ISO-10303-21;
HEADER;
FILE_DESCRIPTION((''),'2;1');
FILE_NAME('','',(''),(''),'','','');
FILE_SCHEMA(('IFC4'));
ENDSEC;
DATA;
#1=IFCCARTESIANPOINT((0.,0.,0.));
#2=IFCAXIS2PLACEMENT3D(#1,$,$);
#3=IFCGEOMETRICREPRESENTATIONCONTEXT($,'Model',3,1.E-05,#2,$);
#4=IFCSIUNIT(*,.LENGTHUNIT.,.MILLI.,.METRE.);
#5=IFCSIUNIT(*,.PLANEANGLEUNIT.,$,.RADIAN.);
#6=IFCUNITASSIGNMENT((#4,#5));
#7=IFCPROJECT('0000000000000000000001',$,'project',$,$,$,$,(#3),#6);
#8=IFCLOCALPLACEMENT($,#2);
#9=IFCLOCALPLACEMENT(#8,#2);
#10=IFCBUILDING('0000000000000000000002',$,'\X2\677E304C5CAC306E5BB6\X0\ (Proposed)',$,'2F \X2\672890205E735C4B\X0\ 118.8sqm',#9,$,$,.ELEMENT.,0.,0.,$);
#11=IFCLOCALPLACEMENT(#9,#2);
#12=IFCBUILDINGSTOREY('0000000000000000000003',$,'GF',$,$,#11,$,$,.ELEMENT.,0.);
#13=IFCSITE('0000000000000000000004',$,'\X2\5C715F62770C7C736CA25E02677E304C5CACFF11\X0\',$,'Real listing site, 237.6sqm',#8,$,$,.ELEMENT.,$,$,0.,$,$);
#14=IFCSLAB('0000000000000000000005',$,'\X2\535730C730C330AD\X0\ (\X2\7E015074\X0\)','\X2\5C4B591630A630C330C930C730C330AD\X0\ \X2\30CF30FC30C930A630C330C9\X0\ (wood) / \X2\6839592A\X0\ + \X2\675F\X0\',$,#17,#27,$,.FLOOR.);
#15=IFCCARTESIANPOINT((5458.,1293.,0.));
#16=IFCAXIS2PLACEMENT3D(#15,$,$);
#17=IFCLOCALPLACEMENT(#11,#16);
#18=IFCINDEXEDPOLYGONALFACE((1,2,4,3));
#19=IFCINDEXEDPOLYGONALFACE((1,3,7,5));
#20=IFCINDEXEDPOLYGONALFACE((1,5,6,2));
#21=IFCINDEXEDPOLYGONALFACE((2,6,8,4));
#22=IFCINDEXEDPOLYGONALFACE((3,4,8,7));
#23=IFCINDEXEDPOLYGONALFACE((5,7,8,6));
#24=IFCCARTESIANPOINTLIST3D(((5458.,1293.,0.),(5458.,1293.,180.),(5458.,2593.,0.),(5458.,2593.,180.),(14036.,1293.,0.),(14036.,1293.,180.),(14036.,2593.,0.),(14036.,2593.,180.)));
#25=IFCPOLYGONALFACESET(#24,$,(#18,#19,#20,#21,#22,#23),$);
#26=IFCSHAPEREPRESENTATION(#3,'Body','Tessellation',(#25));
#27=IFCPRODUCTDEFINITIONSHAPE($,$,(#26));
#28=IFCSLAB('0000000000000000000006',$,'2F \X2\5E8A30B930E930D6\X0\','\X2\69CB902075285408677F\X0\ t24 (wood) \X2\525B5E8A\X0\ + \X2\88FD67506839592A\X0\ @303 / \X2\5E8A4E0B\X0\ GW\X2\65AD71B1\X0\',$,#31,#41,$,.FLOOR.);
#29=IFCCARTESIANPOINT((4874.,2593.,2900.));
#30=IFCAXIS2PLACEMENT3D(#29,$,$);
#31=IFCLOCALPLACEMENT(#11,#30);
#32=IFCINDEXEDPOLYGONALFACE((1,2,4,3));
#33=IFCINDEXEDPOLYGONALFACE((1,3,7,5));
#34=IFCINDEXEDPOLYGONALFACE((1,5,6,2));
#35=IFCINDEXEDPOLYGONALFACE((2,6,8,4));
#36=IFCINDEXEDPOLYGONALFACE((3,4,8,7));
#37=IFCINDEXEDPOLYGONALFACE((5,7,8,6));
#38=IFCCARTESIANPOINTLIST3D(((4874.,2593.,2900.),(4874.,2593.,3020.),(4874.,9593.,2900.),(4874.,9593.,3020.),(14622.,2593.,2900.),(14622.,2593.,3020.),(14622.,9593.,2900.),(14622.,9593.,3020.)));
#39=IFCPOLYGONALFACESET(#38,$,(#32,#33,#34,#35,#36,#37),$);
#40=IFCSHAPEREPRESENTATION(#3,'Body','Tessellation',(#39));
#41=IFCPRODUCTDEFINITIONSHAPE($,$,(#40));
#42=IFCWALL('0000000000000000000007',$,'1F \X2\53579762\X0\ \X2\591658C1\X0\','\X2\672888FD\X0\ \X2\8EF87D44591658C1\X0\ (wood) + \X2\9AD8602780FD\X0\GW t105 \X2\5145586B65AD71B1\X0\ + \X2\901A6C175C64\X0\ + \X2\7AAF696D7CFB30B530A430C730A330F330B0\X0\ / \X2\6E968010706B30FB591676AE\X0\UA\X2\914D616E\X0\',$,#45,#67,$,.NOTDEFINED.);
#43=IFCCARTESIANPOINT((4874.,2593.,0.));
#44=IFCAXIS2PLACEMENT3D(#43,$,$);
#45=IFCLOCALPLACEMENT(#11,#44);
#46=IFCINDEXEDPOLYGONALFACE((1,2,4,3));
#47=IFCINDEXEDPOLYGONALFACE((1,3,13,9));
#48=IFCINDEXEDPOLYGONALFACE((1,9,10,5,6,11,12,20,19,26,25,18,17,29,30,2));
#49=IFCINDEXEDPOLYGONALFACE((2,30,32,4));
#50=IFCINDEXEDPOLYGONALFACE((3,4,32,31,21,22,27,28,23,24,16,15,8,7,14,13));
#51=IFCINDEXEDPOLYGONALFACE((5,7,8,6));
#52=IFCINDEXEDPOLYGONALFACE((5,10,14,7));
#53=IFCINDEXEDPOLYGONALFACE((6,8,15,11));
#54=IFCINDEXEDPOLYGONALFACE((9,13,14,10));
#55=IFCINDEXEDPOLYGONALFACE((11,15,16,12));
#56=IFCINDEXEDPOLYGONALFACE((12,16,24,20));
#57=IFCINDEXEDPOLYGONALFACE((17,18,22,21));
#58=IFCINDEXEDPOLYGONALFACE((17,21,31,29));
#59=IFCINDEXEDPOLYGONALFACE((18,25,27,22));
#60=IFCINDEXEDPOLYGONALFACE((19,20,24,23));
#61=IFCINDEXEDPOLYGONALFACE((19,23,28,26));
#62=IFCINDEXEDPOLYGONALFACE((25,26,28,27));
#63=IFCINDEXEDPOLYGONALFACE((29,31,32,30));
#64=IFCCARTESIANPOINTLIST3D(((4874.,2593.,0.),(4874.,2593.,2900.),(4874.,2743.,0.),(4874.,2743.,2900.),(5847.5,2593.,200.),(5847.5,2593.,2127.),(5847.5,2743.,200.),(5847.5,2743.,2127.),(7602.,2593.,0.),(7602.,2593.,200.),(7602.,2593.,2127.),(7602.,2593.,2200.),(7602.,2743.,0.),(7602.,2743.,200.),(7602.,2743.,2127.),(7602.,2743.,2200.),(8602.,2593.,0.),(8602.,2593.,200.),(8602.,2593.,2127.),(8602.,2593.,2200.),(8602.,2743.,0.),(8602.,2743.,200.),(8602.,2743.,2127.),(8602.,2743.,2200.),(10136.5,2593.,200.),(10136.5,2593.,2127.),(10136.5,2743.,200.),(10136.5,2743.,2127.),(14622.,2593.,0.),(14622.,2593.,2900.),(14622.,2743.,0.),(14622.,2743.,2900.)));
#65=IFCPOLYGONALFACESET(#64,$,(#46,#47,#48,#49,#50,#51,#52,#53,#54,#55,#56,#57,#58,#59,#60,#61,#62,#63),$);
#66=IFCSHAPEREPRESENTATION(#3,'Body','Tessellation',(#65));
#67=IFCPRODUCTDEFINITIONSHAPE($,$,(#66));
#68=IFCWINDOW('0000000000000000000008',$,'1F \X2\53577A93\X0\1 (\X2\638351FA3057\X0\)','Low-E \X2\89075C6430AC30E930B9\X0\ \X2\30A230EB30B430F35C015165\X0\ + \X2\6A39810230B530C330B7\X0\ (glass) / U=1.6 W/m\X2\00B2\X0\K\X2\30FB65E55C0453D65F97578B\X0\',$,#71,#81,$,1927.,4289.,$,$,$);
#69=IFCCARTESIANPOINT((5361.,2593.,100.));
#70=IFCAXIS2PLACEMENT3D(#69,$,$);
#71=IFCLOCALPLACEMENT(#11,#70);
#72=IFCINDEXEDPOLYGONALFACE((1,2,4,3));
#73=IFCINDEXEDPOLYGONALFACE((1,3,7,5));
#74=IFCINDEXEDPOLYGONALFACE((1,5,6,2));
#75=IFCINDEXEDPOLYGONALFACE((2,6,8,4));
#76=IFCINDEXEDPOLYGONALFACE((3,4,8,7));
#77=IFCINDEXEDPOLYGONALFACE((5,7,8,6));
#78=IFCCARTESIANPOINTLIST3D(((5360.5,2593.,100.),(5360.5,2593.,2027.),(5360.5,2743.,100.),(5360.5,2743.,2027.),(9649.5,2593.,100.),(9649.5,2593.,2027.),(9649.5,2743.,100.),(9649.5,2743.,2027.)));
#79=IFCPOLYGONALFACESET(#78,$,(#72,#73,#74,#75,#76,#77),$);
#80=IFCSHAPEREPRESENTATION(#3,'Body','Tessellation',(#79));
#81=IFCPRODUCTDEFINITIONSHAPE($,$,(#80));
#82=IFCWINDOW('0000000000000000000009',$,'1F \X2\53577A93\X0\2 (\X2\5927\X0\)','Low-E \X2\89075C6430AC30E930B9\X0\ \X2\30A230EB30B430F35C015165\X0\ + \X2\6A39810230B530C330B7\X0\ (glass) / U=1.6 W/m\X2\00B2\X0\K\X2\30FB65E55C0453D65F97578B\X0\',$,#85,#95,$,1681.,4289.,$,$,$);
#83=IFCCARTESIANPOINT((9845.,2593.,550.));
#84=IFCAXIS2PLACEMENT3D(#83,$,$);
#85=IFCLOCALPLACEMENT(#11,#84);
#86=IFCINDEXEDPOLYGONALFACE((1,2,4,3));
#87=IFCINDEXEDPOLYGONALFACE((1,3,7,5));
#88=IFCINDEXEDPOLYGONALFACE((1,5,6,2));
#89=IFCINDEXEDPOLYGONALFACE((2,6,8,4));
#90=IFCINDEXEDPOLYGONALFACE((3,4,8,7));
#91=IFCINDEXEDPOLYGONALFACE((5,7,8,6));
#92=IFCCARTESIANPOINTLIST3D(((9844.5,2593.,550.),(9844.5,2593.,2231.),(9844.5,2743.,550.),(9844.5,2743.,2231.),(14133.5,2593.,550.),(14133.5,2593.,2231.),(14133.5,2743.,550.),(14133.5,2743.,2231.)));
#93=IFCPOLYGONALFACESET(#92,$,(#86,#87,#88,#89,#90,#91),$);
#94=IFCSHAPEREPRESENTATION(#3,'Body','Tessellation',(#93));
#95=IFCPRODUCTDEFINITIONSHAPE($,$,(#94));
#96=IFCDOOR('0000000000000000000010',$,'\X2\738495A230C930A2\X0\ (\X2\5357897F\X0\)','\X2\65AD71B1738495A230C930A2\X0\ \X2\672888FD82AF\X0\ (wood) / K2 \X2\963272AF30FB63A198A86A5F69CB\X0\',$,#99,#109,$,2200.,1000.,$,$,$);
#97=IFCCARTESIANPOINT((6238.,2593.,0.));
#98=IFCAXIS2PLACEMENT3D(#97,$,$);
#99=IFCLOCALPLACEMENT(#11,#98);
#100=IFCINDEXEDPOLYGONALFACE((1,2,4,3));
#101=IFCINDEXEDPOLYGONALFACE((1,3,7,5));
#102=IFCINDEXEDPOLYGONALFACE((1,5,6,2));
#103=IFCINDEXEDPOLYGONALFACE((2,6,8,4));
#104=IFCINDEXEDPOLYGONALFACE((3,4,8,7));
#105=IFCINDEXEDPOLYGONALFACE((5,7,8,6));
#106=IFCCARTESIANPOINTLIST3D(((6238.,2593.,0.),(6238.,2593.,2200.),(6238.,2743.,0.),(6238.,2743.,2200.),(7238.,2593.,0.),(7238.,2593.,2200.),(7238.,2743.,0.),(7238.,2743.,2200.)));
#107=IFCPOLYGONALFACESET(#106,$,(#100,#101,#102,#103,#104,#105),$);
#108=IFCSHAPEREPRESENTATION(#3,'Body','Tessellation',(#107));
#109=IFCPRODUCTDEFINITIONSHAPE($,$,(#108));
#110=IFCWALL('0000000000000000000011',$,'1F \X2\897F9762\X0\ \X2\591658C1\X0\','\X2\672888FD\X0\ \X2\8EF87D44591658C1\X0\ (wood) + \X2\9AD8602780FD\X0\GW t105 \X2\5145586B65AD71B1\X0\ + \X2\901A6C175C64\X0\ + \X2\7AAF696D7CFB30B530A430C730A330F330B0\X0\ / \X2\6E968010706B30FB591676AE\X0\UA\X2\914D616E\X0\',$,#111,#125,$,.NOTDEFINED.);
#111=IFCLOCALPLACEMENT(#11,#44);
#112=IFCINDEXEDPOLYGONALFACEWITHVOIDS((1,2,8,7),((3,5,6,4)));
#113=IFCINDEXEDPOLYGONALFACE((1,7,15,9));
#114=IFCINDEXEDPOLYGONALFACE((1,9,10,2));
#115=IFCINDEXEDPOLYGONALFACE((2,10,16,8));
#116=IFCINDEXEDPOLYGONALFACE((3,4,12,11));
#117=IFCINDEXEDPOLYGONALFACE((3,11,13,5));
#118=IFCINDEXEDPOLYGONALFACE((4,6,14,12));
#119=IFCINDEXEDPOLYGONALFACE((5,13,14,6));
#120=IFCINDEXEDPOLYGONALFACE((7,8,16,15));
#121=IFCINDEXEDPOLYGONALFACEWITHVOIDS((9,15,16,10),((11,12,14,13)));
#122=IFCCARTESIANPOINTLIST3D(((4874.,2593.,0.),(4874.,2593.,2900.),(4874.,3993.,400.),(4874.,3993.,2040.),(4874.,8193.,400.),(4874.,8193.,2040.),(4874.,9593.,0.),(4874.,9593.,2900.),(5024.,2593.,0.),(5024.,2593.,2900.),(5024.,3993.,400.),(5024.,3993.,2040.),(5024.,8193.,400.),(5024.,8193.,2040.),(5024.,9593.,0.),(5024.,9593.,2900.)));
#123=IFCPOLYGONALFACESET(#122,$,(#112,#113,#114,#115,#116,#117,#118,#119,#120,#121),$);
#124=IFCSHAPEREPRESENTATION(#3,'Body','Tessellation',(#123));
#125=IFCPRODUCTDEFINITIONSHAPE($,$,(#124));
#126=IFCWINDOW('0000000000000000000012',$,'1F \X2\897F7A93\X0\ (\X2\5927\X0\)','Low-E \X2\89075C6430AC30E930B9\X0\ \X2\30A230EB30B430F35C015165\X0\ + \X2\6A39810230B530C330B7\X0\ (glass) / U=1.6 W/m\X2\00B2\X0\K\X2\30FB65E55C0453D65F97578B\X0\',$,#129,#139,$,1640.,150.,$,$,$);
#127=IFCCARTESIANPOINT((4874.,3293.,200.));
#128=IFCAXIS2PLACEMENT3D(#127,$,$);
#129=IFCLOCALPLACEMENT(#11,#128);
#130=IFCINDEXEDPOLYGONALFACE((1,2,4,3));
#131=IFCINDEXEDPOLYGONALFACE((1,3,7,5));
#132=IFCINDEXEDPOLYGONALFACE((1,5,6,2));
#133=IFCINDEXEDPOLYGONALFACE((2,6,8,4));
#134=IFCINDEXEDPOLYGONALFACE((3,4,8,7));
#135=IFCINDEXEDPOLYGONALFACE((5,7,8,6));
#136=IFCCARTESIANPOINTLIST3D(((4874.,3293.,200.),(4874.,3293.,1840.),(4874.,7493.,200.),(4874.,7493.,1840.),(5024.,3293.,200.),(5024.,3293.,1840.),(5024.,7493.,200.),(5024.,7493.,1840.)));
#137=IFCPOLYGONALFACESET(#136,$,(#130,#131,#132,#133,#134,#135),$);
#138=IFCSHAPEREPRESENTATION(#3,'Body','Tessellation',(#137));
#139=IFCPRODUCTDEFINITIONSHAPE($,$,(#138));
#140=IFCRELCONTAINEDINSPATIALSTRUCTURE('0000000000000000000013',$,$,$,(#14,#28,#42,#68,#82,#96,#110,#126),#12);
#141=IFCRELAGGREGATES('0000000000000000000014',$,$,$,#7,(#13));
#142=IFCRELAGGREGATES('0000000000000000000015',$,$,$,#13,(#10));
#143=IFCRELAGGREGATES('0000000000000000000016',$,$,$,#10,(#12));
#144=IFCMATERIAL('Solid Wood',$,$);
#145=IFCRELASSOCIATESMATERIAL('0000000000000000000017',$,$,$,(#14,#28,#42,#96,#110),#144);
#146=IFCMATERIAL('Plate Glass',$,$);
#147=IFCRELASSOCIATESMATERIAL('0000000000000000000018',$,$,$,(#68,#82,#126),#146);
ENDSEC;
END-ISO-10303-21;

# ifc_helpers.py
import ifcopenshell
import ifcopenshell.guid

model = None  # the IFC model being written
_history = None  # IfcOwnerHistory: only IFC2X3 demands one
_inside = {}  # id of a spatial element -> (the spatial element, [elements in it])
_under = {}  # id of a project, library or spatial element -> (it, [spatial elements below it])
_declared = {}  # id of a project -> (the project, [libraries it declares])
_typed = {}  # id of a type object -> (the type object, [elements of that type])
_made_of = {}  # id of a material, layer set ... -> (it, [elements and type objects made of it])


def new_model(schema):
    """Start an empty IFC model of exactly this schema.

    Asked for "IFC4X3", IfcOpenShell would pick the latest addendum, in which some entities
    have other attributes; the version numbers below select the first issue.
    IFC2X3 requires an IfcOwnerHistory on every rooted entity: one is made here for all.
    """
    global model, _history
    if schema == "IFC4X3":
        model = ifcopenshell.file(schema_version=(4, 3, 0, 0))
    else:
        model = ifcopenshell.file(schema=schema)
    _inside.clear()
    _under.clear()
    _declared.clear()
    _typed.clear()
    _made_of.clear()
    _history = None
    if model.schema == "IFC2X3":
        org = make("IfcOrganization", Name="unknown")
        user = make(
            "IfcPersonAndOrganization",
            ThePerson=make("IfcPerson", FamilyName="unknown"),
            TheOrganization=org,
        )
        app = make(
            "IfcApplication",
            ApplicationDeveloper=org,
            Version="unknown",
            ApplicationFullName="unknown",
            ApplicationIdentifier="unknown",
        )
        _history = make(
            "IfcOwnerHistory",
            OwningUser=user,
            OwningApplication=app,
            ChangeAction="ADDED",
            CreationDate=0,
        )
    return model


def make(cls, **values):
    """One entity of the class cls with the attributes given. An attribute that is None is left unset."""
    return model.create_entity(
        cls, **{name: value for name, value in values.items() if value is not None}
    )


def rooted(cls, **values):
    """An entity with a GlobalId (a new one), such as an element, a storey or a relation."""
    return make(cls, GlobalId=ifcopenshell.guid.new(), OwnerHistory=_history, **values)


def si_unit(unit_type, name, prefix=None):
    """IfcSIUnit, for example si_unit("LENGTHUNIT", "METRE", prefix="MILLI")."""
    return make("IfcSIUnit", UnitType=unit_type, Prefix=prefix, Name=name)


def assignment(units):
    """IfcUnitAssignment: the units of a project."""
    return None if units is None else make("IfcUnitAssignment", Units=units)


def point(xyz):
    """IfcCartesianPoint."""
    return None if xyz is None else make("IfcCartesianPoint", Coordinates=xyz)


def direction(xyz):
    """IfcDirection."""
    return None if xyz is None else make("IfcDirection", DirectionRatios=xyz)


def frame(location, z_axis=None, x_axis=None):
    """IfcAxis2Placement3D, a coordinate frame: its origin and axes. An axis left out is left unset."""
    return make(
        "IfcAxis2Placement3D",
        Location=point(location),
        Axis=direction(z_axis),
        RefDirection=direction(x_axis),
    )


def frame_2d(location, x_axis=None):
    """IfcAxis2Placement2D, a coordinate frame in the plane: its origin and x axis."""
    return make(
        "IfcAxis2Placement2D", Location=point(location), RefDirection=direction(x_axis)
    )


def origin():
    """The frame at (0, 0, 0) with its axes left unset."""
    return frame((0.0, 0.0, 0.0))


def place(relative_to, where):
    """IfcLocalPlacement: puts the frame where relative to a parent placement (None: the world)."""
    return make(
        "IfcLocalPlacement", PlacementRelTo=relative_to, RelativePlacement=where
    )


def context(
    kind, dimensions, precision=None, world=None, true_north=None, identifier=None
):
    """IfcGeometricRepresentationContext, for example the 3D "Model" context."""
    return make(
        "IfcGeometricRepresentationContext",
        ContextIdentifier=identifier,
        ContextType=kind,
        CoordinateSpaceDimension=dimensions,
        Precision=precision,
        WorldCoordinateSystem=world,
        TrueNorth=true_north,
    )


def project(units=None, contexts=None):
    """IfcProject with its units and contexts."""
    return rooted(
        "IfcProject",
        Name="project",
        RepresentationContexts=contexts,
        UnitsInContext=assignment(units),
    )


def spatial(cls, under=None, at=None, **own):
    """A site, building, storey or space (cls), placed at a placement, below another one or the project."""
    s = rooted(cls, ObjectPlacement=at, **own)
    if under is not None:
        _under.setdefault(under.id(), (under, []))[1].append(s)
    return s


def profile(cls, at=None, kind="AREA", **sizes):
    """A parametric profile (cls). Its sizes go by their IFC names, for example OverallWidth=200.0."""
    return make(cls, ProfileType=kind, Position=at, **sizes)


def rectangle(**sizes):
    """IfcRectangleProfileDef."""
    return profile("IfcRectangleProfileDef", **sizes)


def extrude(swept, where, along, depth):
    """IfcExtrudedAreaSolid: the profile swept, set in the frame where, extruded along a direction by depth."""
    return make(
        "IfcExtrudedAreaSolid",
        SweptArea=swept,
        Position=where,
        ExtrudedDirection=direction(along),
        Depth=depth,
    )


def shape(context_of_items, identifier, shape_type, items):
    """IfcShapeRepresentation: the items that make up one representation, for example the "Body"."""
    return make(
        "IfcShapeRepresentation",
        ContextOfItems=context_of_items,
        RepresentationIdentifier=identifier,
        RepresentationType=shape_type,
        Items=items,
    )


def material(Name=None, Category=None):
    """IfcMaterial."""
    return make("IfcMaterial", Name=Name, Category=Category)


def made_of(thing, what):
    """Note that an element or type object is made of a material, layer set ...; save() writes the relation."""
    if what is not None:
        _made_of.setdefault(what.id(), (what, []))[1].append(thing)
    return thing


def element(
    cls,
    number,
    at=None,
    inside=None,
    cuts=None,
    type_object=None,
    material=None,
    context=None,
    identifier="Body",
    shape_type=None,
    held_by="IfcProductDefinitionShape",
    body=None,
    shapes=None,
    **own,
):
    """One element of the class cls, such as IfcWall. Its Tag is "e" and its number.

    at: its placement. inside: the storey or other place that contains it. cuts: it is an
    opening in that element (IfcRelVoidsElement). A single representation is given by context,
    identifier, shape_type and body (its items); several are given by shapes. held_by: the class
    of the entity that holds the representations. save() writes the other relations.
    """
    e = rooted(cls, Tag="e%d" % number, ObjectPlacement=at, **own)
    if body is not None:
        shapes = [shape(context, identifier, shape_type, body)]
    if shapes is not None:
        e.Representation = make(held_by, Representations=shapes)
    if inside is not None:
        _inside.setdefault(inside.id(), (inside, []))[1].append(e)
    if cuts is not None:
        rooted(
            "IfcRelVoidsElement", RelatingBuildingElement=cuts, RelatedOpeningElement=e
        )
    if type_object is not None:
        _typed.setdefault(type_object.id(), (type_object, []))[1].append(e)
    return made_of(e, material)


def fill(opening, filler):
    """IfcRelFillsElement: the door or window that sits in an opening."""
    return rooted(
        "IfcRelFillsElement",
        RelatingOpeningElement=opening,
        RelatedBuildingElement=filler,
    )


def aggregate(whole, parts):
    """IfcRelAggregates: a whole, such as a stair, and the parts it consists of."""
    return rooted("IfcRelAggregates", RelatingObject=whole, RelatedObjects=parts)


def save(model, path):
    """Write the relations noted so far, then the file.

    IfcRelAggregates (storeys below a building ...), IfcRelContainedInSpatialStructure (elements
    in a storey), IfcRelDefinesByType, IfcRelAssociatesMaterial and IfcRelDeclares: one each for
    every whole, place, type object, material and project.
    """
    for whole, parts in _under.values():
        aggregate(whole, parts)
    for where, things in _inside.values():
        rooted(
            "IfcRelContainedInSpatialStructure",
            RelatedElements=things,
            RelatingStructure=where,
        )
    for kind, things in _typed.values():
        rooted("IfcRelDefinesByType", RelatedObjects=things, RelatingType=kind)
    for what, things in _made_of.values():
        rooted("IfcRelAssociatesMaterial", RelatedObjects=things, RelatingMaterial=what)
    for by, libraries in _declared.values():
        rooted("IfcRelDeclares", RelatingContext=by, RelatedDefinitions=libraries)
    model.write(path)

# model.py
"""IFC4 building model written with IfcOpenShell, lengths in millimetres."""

from ifc_helpers import new_model, si_unit, frame, frame_2d, origin, place, context, project, spatial, rectangle, extrude, material, element, fill, save


model = new_model("IFC4")

# Units and contexts
model_context = context("Model", 3, precision=1e-05, world=origin())
ifc_project = project(units=[si_unit("LENGTHUNIT", "METRE", prefix="MILLI"), si_unit("PLANEANGLEUNIT", "RADIAN")], contexts=[model_context])

# Site, building, storey
site_placement = place(None, origin())
site = spatial("IfcSite", under=ifc_project, at=site_placement, Name="山形県米沢市松が岬１", ObjectType="Real listing site, 237.6sqm", CompositionType="ELEMENT", RefElevation=0.0)
building_placement = place(site_placement, origin())
building = spatial("IfcBuilding", under=site, at=building_placement, Name="松が岬の家 (Proposed)", ObjectType="2F 木造平屋 118.8sqm", CompositionType="ELEMENT", ElevationOfRefHeight=0.0, ElevationOfTerrain=0.0)
storey_placement = place(building_placement, origin())
storey = spatial("IfcBuildingStorey", under=building, at=storey_placement, Name="GF", CompositionType="ELEMENT", Elevation=0.0)

# Slabs
ifc_material_1 = material(Name="Solid Wood")
slab_1_placement = place(storey_placement, frame((5458.0, 1293.0, 0.0)))
element("IfcSlab", 1, at=slab_1_placement, inside=storey, material=ifc_material_1, Name="南デッキ (縁側)", Description="屋外ウッドデッキ ハードウッド (wood) / 根太 + 束", PredefinedType="FLOOR", context=model_context, shape_type="SweptSolid", body=[
    extrude(rectangle(XDim=8578.0, YDim=1300.0, at=frame_2d((4289.0, 650.0))), frame((5458.0, 1293.0, 0.0)), (0.0, 0.0, 1.0), 180.0),
])
slab_2_placement = place(storey_placement, frame((4874.0, 2593.0, 2900.0)))
element("IfcSlab", 2, at=slab_2_placement, inside=storey, material=ifc_material_1, Name="2F 床スラブ", Description="構造用合板 t24 (wood) 剛床 + 製材根太 @303 / 床下 GW断熱", PredefinedType="FLOOR", context=model_context, shape_type="SweptSolid", body=[
    extrude(rectangle(XDim=9748.0, YDim=7000.0, at=frame_2d((4874.0, 3500.0))), frame((4874.0, 2593.0, 2900.0)), (0.0, 0.0, 1.0), 120.0),
])

# Wall, openings, windows, door
wall_1_placement = place(storey_placement, frame((4874.0, 2593.0, 0.0)))
wall_1 = element("IfcWall", 3, at=wall_1_placement, inside=storey, material=ifc_material_1, Name="1F 南面 外壁", Description="木製 軸組外壁 (wood) + 高性能GW t105 充填断熱 + 通気層 + 窯業系サイディング / 準耐火・外皮UA配慮", PredefinedType="NOTDEFINED", context=model_context, shape_type="SweptSolid", body=[
    extrude(rectangle(XDim=9748.0, YDim=150.0, at=frame_2d((4874.0, 75.0))), frame((4874.0, 2593.0, 0.0)), (0.0, 0.0, 1.0), 2900.0),
])
opening_1_placement = place(storey_placement, frame((5361.0, 2593.0, 100.0)))
opening_1 = element("IfcOpeningElement", 4, at=opening_1_placement, cuts=wall_1, PredefinedType="NOTDEFINED", context=model_context, shape_type="SweptSolid", body=[
    extrude(rectangle(XDim=4289.0, YDim=150.0, at=frame_2d((2144.0, 75.0))), frame((5361.0, 2593.0, 100.0)), (0.0, 0.0, 1.0), 1927.0),
])
opening_2_placement = place(storey_placement, frame((9845.0, 2593.0, 550.0)))
opening_2 = element("IfcOpeningElement", 5, at=opening_2_placement, cuts=wall_1, PredefinedType="NOTDEFINED", context=model_context, shape_type="SweptSolid", body=[
    extrude(rectangle(XDim=4289.0, YDim=150.0, at=frame_2d((2144.0, 75.0))), frame((9845.0, 2593.0, 550.0)), (0.0, 0.0, 1.0), 1681.0),
])
opening_3_placement = place(storey_placement, frame((6238.0, 2593.0, 0.0)))
opening_3 = element("IfcOpeningElement", 6, at=opening_3_placement, cuts=wall_1, PredefinedType="NOTDEFINED", context=model_context, shape_type="SweptSolid", body=[
    extrude(rectangle(XDim=1000.0, YDim=150.0, at=frame_2d((500.0, 75.0))), frame((6238.0, 2593.0, 0.0)), (0.0, 0.0, 1.0), 2200.0),
])
ifc_material_2 = material(Name="Plate Glass")
window_1_placement = place(storey_placement, frame((5361.0, 2593.0, 100.0)))
window_1 = element("IfcWindow", 7, at=window_1_placement, inside=storey, material=ifc_material_2, Name="1F 南窓1 (掃出し)", Description="Low-E 複層ガラス アルゴン封入 + 樹脂サッシ (glass) / U=1.6 W/m²K・日射取得型", OverallHeight=1927.0, OverallWidth=4289.0, context=model_context, shape_type="SweptSolid", body=[
    extrude(rectangle(XDim=4289.0, YDim=150.0, at=frame_2d((2144.0, 75.0))), frame((5361.0, 2593.0, 100.0)), (0.0, 0.0, 1.0), 1927.0),
])
fill(opening_1, window_1)
window_2_placement = place(storey_placement, frame((9845.0, 2593.0, 550.0)))
window_2 = element("IfcWindow", 8, at=window_2_placement, inside=storey, material=ifc_material_2, Name="1F 南窓2 (大)", Description="Low-E 複層ガラス アルゴン封入 + 樹脂サッシ (glass) / U=1.6 W/m²K・日射取得型", OverallHeight=1681.0, OverallWidth=4289.0, context=model_context, shape_type="SweptSolid", body=[
    extrude(rectangle(XDim=4289.0, YDim=150.0, at=frame_2d((2144.0, 75.0))), frame((9845.0, 2593.0, 550.0)), (0.0, 0.0, 1.0), 1681.0),
])
fill(opening_2, window_2)
door_placement = place(storey_placement, frame((6238.0, 2593.0, 0.0)))
door = element("IfcDoor", 9, at=door_placement, inside=storey, material=ifc_material_1, Name="玄関ドア (南西)", Description="断熱玄関ドア 木製芯 (wood) / K2 防犯・採風機構", OverallHeight=2200.0, OverallWidth=1000.0, context=model_context, shape_type="SweptSolid", body=[
    extrude(rectangle(XDim=1000.0, YDim=150.0, at=frame_2d((500.0, 75.0))), frame((6238.0, 2593.0, 0.0)), (0.0, 0.0, 1.0), 2200.0),
])
fill(opening_3, door)

# Wall, opening, window
wall_2_placement = place(storey_placement, frame((4874.0, 2593.0, 0.0)))
wall_2 = element("IfcWall", 10, at=wall_2_placement, inside=storey, material=ifc_material_1, Name="1F 西面 外壁", Description="木製 軸組外壁 (wood) + 高性能GW t105 充填断熱 + 通気層 + 窯業系サイディング / 準耐火・外皮UA配慮", PredefinedType="NOTDEFINED", context=model_context, shape_type="SweptSolid", body=[
    extrude(rectangle(XDim=150.0, YDim=7000.0, at=frame_2d((75.0, 3500.0))), frame((4874.0, 2593.0, 0.0)), (0.0, 0.0, 1.0), 2900.0),
])
opening_4_placement = place(storey_placement, frame((4874.0, 3293.0, 200.0)))
opening_4 = element("IfcOpeningElement", 11, at=opening_4_placement, cuts=wall_2, PredefinedType="NOTDEFINED", context=model_context, shape_type="SweptSolid", body=[
    extrude(rectangle(XDim=150.0, YDim=4200.0, at=frame_2d((75.0, 2100.0))), frame((4874.0, 3293.0, 200.0)), (0.0, 0.0, 1.0), 1640.0),
])
window_3_placement = place(storey_placement, frame((4874.0, 3293.0, 200.0)))
window_3 = element("IfcWindow", 12, at=window_3_placement, inside=storey, material=ifc_material_2, Name="1F 西窓 (大)", Description="Low-E 複層ガラス アルゴン封入 + 樹脂サッシ (glass) / U=1.6 W/m²K・日射取得型", OverallHeight=1640.0, OverallWidth=150.0, context=model_context, shape_type="SweptSolid", body=[
    extrude(rectangle(XDim=150.0, YDim=4200.0, at=frame_2d((75.0, 2100.0))), frame((4874.0, 3293.0, 200.0)), (0.0, 0.0, 1.0), 1640.0),
])
fill(opening_4, window_3)

save(model, "model.ifc")
